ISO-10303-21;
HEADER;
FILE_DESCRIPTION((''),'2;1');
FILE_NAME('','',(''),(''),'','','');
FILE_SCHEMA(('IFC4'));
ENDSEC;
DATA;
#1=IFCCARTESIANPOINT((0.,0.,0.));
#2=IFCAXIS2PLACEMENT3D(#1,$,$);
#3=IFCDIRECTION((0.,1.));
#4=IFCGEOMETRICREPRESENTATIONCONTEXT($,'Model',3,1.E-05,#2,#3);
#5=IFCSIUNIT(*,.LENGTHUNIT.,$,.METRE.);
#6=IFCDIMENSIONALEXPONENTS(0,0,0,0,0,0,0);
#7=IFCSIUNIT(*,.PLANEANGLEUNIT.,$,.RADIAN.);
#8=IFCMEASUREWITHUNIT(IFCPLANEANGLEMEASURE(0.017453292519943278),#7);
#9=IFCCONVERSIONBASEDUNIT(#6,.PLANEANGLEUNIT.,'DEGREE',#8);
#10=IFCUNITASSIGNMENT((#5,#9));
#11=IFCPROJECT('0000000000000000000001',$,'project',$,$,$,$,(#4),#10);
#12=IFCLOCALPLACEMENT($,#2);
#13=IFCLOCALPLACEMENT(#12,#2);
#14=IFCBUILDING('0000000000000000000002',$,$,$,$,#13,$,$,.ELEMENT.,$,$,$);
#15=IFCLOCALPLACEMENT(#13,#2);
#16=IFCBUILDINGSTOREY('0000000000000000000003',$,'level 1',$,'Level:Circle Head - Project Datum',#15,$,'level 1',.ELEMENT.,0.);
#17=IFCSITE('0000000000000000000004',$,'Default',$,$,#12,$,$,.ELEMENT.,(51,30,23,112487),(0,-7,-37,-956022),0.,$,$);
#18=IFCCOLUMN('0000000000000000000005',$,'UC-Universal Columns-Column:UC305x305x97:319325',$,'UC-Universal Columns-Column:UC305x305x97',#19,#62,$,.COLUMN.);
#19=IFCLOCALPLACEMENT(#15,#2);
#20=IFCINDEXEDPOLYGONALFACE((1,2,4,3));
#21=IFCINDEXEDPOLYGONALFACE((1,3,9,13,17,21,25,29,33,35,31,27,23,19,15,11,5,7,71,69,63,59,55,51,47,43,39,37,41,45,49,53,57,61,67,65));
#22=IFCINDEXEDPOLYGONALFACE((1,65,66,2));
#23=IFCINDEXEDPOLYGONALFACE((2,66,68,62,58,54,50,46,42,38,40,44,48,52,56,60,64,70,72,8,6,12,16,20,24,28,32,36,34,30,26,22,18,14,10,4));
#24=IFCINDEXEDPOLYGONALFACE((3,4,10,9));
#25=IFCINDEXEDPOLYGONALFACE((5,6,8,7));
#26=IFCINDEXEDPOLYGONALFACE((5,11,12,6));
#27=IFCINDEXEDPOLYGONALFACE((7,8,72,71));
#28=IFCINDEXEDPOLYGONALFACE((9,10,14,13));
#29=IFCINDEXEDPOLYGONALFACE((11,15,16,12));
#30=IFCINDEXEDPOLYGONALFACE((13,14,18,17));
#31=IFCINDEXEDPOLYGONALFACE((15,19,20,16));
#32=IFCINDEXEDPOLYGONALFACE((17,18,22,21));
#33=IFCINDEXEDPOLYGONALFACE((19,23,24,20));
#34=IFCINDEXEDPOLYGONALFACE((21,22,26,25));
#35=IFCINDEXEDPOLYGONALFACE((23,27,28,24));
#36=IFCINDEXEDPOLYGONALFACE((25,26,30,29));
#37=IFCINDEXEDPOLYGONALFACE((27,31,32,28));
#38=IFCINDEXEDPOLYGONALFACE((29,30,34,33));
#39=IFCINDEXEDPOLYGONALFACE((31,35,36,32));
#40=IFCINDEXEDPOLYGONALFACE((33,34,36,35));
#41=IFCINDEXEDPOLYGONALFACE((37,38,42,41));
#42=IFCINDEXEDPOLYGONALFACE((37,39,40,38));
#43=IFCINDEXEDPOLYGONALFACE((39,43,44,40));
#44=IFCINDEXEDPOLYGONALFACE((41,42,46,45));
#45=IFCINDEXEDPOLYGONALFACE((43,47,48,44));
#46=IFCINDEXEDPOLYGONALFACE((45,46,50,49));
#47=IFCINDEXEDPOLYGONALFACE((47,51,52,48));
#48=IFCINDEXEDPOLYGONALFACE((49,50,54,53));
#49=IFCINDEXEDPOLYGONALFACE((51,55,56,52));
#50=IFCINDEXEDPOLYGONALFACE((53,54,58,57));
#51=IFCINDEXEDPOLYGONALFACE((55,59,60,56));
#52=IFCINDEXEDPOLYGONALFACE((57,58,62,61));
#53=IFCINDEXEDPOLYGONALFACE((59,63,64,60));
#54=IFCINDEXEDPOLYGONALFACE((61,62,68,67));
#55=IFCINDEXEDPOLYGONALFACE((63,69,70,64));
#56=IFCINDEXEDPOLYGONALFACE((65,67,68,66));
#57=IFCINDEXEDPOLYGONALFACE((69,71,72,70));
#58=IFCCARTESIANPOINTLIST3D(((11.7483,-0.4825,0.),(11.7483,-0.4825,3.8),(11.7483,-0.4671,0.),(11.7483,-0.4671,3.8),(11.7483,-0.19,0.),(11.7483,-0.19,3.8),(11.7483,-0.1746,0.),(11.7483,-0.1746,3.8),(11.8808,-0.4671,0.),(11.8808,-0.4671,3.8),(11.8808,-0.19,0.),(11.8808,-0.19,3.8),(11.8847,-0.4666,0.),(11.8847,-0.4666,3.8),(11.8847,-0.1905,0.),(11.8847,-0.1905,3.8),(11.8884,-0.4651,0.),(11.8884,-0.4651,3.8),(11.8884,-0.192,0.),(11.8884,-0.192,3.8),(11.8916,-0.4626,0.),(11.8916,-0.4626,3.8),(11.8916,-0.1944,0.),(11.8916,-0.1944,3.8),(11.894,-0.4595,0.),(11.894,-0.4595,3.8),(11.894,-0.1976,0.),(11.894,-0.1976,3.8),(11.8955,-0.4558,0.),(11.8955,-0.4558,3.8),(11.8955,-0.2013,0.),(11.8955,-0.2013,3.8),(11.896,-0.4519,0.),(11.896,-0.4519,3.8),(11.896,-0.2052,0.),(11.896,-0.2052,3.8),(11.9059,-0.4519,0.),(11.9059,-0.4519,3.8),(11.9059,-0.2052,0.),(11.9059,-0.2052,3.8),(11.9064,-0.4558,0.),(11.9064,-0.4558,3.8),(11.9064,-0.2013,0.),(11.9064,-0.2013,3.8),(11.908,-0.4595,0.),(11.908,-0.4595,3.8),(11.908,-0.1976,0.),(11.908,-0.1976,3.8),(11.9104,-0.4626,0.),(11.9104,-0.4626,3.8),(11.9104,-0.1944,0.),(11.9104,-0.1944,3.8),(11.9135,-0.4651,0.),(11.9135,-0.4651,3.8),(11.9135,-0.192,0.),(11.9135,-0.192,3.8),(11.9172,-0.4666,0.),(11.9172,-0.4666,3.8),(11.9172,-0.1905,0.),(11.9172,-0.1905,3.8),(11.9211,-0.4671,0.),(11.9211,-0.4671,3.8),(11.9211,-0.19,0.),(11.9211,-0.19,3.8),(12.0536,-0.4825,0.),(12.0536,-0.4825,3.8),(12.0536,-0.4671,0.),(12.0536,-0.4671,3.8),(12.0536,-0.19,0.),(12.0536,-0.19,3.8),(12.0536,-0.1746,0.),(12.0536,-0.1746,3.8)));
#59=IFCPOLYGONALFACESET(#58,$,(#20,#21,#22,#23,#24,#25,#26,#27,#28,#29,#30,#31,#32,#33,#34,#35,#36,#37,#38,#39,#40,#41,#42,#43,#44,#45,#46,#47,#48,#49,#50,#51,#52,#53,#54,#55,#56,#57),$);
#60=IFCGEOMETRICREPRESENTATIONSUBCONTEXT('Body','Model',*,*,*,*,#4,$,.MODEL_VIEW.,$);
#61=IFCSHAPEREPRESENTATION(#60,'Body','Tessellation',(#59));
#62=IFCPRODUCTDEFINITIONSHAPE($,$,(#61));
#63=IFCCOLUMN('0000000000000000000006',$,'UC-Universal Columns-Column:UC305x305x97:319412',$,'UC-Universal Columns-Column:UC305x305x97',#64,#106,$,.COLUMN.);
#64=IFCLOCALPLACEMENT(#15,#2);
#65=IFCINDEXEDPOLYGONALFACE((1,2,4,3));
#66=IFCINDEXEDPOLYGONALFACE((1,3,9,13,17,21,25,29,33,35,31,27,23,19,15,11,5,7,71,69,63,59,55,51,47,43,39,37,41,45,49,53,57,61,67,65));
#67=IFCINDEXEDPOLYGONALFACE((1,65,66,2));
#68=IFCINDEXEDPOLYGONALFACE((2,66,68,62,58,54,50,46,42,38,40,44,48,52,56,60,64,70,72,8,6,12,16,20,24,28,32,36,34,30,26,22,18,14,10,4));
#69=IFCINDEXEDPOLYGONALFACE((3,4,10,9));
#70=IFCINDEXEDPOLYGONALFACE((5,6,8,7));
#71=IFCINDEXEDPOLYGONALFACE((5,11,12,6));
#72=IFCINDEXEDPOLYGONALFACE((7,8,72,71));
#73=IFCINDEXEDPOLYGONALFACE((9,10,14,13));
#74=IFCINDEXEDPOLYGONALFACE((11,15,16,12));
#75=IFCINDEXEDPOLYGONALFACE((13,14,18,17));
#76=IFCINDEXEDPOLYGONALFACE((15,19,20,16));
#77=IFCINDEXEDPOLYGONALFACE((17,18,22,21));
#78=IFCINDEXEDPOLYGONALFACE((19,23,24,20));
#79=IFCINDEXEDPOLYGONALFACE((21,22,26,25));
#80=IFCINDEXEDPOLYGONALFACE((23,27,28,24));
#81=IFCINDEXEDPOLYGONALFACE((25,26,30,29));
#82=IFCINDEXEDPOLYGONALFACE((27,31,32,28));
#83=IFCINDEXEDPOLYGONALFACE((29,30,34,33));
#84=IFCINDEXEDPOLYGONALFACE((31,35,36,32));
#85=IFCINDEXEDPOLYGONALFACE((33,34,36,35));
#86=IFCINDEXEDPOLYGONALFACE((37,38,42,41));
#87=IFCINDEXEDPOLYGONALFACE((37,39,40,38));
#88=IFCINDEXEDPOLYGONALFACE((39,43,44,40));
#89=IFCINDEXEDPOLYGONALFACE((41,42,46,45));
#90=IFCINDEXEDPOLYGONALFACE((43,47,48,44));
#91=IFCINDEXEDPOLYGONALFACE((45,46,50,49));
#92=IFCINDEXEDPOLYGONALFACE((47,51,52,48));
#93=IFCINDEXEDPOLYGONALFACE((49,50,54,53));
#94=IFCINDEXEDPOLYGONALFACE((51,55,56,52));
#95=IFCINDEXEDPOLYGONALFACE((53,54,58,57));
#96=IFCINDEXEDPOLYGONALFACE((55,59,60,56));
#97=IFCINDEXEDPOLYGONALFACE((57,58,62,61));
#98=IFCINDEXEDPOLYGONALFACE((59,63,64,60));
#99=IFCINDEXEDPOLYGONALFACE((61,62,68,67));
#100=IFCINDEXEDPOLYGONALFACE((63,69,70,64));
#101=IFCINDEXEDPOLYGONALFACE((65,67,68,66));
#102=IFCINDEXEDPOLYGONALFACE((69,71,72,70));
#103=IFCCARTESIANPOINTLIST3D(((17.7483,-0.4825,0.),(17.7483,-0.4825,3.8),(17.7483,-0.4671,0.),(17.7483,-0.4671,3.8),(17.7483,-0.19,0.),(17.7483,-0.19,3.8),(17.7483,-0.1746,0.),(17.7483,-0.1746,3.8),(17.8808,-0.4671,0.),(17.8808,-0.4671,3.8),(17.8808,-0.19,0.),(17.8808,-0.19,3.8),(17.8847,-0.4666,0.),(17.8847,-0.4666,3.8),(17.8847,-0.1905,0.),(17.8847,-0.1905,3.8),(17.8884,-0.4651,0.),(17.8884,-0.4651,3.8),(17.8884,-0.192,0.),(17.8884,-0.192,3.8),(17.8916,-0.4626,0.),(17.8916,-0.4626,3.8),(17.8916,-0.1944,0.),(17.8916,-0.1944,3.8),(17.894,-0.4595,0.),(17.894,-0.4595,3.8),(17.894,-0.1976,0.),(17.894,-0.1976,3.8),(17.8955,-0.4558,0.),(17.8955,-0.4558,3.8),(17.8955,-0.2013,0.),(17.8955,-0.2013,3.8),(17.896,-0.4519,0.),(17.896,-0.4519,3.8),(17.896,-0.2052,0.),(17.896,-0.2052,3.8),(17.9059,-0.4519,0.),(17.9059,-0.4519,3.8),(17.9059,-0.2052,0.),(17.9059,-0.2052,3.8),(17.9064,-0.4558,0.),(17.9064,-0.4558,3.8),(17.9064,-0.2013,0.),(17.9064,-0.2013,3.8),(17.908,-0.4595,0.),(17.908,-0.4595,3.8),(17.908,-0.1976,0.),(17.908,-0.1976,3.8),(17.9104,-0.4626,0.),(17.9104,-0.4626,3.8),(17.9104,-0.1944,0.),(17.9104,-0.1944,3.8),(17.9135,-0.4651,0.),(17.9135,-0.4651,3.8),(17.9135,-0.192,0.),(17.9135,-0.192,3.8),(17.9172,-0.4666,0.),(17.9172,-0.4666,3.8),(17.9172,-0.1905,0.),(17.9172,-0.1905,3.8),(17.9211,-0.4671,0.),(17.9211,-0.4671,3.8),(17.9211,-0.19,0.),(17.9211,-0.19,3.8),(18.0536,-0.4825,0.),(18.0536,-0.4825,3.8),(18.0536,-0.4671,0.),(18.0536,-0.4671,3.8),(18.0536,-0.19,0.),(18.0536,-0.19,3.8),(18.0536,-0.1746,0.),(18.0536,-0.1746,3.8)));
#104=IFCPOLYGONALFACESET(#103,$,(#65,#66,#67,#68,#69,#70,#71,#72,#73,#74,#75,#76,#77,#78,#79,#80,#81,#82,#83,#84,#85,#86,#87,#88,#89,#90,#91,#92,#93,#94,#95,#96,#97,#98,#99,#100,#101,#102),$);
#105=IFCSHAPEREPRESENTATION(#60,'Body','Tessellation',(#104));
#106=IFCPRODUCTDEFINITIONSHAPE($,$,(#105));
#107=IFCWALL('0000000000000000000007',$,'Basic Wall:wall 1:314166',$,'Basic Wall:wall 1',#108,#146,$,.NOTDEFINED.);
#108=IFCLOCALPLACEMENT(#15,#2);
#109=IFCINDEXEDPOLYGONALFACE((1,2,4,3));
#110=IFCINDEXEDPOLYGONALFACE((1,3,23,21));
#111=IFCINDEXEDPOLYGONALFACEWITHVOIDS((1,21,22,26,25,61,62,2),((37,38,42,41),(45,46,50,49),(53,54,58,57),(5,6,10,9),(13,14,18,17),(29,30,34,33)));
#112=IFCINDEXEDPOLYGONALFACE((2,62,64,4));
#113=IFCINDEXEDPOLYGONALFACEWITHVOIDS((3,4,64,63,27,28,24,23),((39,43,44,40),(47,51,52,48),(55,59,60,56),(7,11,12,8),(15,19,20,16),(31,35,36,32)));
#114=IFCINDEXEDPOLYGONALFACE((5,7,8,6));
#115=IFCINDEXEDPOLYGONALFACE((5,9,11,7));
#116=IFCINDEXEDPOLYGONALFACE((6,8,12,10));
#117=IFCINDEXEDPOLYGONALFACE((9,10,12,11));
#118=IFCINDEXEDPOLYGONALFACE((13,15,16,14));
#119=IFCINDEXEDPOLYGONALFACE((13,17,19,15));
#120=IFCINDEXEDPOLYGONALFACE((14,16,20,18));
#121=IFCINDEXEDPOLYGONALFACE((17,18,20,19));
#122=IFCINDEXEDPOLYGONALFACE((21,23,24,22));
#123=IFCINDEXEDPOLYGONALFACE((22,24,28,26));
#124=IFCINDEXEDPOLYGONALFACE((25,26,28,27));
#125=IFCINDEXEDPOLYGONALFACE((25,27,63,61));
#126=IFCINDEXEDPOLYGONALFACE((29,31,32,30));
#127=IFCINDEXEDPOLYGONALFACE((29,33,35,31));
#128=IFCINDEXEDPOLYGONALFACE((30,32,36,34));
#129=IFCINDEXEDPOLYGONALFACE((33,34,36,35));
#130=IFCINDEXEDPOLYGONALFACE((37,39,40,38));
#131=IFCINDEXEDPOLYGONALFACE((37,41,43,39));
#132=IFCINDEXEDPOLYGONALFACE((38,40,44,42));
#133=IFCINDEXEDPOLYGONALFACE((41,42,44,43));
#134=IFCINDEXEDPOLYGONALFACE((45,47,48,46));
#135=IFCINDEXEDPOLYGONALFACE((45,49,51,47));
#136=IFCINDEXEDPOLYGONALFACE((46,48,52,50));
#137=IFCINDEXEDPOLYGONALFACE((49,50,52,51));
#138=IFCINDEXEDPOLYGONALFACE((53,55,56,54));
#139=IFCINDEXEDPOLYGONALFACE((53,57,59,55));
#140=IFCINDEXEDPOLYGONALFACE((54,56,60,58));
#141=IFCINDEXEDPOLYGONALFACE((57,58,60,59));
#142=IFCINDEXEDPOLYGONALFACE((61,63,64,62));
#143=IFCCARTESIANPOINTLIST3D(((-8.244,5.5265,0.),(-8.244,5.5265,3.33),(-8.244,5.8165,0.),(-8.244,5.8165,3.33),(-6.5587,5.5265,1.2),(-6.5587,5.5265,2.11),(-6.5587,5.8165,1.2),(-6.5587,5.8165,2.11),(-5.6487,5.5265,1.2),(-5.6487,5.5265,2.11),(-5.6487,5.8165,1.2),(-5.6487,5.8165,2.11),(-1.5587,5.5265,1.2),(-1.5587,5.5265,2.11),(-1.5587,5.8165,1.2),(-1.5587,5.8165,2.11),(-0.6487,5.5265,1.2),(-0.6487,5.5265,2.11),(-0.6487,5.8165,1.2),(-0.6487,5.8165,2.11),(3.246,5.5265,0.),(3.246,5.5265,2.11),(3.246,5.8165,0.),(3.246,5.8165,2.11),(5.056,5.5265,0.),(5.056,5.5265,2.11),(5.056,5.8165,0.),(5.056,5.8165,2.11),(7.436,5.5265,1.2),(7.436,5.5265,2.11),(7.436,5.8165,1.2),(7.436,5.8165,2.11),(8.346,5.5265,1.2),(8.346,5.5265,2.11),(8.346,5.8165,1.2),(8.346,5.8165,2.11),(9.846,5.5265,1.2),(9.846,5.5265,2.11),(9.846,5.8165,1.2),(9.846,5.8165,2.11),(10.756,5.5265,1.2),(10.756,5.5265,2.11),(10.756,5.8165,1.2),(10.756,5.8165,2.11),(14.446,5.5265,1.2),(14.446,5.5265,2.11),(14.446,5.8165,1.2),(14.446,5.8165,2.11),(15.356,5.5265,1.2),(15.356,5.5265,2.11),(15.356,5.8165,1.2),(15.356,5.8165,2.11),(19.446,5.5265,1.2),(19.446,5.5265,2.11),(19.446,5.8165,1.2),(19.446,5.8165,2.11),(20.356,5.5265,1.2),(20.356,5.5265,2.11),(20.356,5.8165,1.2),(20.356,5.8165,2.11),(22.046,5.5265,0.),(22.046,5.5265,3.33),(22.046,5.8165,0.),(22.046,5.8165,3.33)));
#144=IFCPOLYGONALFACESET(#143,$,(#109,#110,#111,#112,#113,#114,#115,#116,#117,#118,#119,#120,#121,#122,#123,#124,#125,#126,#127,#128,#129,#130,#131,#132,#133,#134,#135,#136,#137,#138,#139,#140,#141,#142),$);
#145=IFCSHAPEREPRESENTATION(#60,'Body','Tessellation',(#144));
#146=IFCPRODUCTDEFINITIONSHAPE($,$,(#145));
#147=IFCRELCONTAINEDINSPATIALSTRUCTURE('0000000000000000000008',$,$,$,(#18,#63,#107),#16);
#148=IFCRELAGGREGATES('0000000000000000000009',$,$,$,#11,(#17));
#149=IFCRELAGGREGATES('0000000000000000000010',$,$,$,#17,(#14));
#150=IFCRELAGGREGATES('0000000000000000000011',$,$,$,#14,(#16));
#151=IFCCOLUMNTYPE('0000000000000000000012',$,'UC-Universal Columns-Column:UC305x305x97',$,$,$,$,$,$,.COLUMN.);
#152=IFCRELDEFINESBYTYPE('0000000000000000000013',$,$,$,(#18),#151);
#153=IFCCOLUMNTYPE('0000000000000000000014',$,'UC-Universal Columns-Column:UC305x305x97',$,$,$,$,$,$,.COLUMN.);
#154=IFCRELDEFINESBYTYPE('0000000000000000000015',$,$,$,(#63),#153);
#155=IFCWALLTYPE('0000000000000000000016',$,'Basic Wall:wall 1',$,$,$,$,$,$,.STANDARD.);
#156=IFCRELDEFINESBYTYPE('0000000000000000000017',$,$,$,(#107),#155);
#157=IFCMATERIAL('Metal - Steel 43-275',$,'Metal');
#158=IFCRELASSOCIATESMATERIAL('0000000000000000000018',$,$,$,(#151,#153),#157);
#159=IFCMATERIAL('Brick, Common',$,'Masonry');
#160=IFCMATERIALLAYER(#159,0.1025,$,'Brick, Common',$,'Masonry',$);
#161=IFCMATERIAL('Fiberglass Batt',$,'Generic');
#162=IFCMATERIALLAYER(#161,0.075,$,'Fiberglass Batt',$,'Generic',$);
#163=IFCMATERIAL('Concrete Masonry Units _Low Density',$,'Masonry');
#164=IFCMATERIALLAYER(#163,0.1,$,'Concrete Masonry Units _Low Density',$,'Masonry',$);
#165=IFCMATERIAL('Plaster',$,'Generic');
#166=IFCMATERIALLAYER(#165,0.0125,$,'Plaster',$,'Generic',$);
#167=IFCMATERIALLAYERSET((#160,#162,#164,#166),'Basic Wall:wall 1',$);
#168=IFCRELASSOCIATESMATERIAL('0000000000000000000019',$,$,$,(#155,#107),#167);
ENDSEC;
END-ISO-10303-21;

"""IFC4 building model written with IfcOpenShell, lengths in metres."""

from ifc_helpers import new_model, entity, si_unit, converted_unit, direction, frame, frame_2d, origin, place, context, subcontext, project, spatial, polyline, rectangle, i_section, extrude, clip, bounded_halfspace, source, transform, mapped, material, layer, layer_set, layer_usage, material_profile, profile_set, type_object, type_shapes, element, save


model = new_model("IFC4")

# Units and contexts
model_context = context("Model", 3, precision=1e-05, world=origin(), true_north=direction((0.0, 1.0)))
body_context = subcontext(model_context, "Body", "Model", "MODEL_VIEW")
ifc_project = project(units=[si_unit("LENGTHUNIT", "METRE"), converted_unit("PLANEANGLEUNIT", "DEGREE", entity("IfcPlaneAngleMeasure", 0.017453292519943278), si_unit("PLANEANGLEUNIT", "RADIAN"), dimensions=[0, 0, 0, 0, 0, 0, 0])], contexts=[model_context])

# Site, building, storey
site_placement = place(None, origin())
site = spatial("IfcSite", under=ifc_project, at=site_placement, Name="Default", CompositionType="ELEMENT", RefLatitude=(51, 30, 23, 112487), RefLongitude=(0, -7, -37, -956022), RefElevation=0.0)
building_placement = place(site_placement, origin())
building = spatial("IfcBuilding", under=site, at=building_placement, CompositionType="ELEMENT")
storey_placement = place(building_placement, origin())
storey = spatial("IfcBuildingStorey", under=building, at=storey_placement, Name="level 1", ObjectType="Level:Circle Head - Project Datum", LongName="level 1", CompositionType="ELEMENT", Elevation=0.0)

# Columns
ifc_material_1 = material(Name="Metal - Steel 43-275", Category="Metal")
ifc_material_profile = material_profile(ifc_material_1, i_section(OverallWidth=0.3053, OverallDepth=0.3079, WebThickness=0.0099, FlangeThickness=0.0154, FilletRadius=0.0152, at=frame_2d((0.0, 0.0), x_axis=(1.0, 0.0))), Name="UC305x305x97")
ifc_profile_set = profile_set([ifc_material_profile], Name="UC305x305x97")
column_type_1 = type_object("IfcColumnType", Name="UC-Universal Columns-Column:UC305x305x97", PredefinedType="COLUMN", material=ifc_profile_set)
shared_shape_1 = source(origin(), body_context, "Body", "SweptSolid", [
    extrude(i_section(OverallWidth=0.3053, OverallDepth=0.3079, WebThickness=0.0099, FlangeThickness=0.0154, FilletRadius=0.0152, at=frame_2d((0.0, 0.0), x_axis=(1.0, 0.0))), frame((11.901, -0.3285, 0.0), z_axis=(0.0, 0.0, 1.0), x_axis=(-1.0, 0.0, 0.0)), (0.0, 0.0, 1.0), 3.8),
])
type_shapes(column_type_1, [shared_shape_1])
column_1_placement = place(storey_placement, origin())
element("IfcColumn", 1, at=column_1_placement, inside=storey, type_object=column_type_1, Name="UC-Universal Columns-Column:UC305x305x97:319325", ObjectType="UC-Universal Columns-Column:UC305x305x97", PredefinedType="COLUMN", context=body_context, shape_type="MappedRepresentation", body=[
    mapped(shared_shape_1, transform((0.0, 0.0, 0.0), scale=1.0)),
])
column_type_2 = type_object("IfcColumnType", Name="UC-Universal Columns-Column:UC305x305x97", PredefinedType="COLUMN", material=ifc_profile_set)
shared_shape_2 = source(origin(), body_context, "Body", "SweptSolid", [
    extrude(i_section(OverallWidth=0.3053, OverallDepth=0.3079, WebThickness=0.0099, FlangeThickness=0.0154, FilletRadius=0.0152, at=frame_2d((0.0, 0.0), x_axis=(1.0, 0.0))), frame((17.901, -0.3285, 0.0), z_axis=(0.0, 0.0, 1.0), x_axis=(-1.0, 0.0, 0.0)), (0.0, 0.0, 1.0), 3.8),
])
type_shapes(column_type_2, [shared_shape_2])
column_2_placement = place(storey_placement, origin())
element("IfcColumn", 2, at=column_2_placement, inside=storey, type_object=column_type_2, Name="UC-Universal Columns-Column:UC305x305x97:319412", ObjectType="UC-Universal Columns-Column:UC305x305x97", PredefinedType="COLUMN", context=body_context, shape_type="MappedRepresentation", body=[
    mapped(shared_shape_2, transform((0.0, 0.0, 0.0), scale=1.0)),
])

# Wall, openings
ifc_material_2 = material(Name="Brick, Common", Category="Masonry")
ifc_layer_1 = layer(ifc_material_2, 0.1025, Name="Brick, Common", Category="Masonry")
ifc_material_3 = material(Name="Fiberglass Batt", Category="Generic")
ifc_layer_2 = layer(ifc_material_3, 0.075, Name="Fiberglass Batt", Category="Generic")
ifc_material_4 = material(Name="Concrete Masonry Units _Low Density", Category="Masonry")
ifc_layer_3 = layer(ifc_material_4, 0.1, Name="Concrete Masonry Units _Low Density", Category="Masonry")
ifc_material_5 = material(Name="Plaster", Category="Generic")
ifc_layer_4 = layer(ifc_material_5, 0.0125, Name="Plaster", Category="Generic")
ifc_layer_set_1 = layer_set([ifc_layer_1, ifc_layer_2, ifc_layer_3, ifc_layer_4], Name="Basic Wall:wall 1")
ifc_layer_usage_1 = layer_usage(ifc_layer_set_1, "AXIS2", "NEGATIVE", 0.145)
wall_type_1 = type_object("IfcWallType", Name="Basic Wall:wall 1", PredefinedType="STANDARD", material=ifc_layer_set_1)
wall_1_placement = place(storey_placement, frame((-8.244, 5.6715, 0.0)))
wall_1 = element("IfcWall", 3, at=wall_1_placement, inside=storey, type_object=wall_type_1, material=ifc_layer_usage_1, Name="Basic Wall:wall 1:314166", ObjectType="Basic Wall:wall 1", PredefinedType="NOTDEFINED", context=body_context, shape_type="Clipping", body=[
    clip(extrude(rectangle(XDim=30.29, YDim=0.29, at=frame_2d((15.145, 0.0), x_axis=(1.0, 0.0))), origin(), (0.0, 0.0, 1.0), 3.33), bounded_halfspace(frame((0.0, -0.145, 3.33), z_axis=(0.0, 0.0, -1.0), x_axis=(0.0, 1.0, 0.0)), True, frame((0.0, -0.145, 3.33)), polyline([(0.0, 0.0), (0.29, 0.0), (4.0731, 0.0), (4.1981, 0.0), (10.0825, 0.0), (10.2075, 0.0), (20.0825, 0.0), (20.2075, 0.0), (26.0825, 0.0), (26.2075, 0.0), (30.0, 0.0), (30.29, 0.0), (30.29, 0.29), (0.0, 0.29), (0.0, 0.0)]))),
])
opening_1_placement = place(wall_1_placement, frame((13.3, 0.145, 0.0)))
element("IfcOpeningElement", 4, at=opening_1_placement, cuts=wall_1, PredefinedType="OPENING", context=body_context, shape_type="SweptSolid", body=[
    extrude(rectangle(XDim=2.11, YDim=1.81, at=frame_2d((1.055, 0.905), x_axis=(-1.0, 0.0))), frame((0.0, 0.0, 0.0), z_axis=(0.0, -1.0, 0.0), x_axis=(0.0, 0.0, 1.0)), (0.0, 0.0, 1.0), 0.29),
])
opening_2_placement = place(wall_1_placement, frame((1.6853, -0.145, 1.2)))
element("IfcOpeningElement", 5, at=opening_2_placement, cuts=wall_1, PredefinedType="OPENING", context=body_context, shape_type="SweptSolid", body=[
    extrude(rectangle(XDim=0.91, YDim=0.91, at=frame_2d((0.455, 0.455), x_axis=(-1.0, 0.0))), frame((0.0, 0.0, 0.0), z_axis=(0.0, 1.0, 0.0), x_axis=(0.0, 0.0, 1.0)), (0.0, 0.0, 1.0), 0.29),
])
opening_3_placement = place(wall_1_placement, frame((6.6853, -0.145, 1.2)))
element("IfcOpeningElement", 6, at=opening_3_placement, cuts=wall_1, PredefinedType="OPENING", context=body_context, shape_type="SweptSolid", body=[
    extrude(rectangle(XDim=0.91, YDim=0.91, at=frame_2d((0.455, 0.455), x_axis=(-1.0, 0.0))), frame((0.0, 0.0, 0.0), z_axis=(0.0, 1.0, 0.0), x_axis=(0.0, 0.0, 1.0)), (0.0, 0.0, 1.0), 0.29),
])
opening_4_placement = place(wall_1_placement, frame((22.69, -0.145, 1.2)))
element("IfcOpeningElement", 7, at=opening_4_placement, cuts=wall_1, PredefinedType="OPENING", context=body_context, shape_type="SweptSolid", body=[
    extrude(rectangle(XDim=0.91, YDim=0.91, at=frame_2d((0.455, 0.455), x_axis=(-1.0, 0.0))), frame((0.0, 0.0, 0.0), z_axis=(0.0, 1.0, 0.0), x_axis=(0.0, 0.0, 1.0)), (0.0, 0.0, 1.0), 0.29),
])
opening_5_placement = place(wall_1_placement, frame((27.69, -0.145, 1.2)))
element("IfcOpeningElement", 8, at=opening_5_placement, cuts=wall_1, PredefinedType="OPENING", context=body_context, shape_type="SweptSolid", body=[
    extrude(rectangle(XDim=0.91, YDim=0.91, at=frame_2d((0.455, 0.455), x_axis=(-1.0, 0.0))), frame((0.0, 0.0, 0.0), z_axis=(0.0, 1.0, 0.0), x_axis=(0.0, 0.0, 1.0)), (0.0, 0.0, 1.0), 0.29),
])
opening_6_placement = place(wall_1_placement, frame((18.09, -0.145, 1.2)))
element("IfcOpeningElement", 9, at=opening_6_placement, cuts=wall_1, PredefinedType="OPENING", context=body_context, shape_type="SweptSolid", body=[
    extrude(rectangle(XDim=0.91, YDim=0.91, at=frame_2d((0.455, 0.455), x_axis=(-1.0, 0.0))), frame((0.0, 0.0, 0.0), z_axis=(0.0, 1.0, 0.0), x_axis=(0.0, 0.0, 1.0)), (0.0, 0.0, 1.0), 0.29),
])
opening_7_placement = place(wall_1_placement, frame((15.68, -0.145, 1.2)))
element("IfcOpeningElement", 10, at=opening_7_placement, cuts=wall_1, PredefinedType="OPENING", context=body_context, shape_type="SweptSolid", body=[
    extrude(rectangle(XDim=0.91, YDim=0.91, at=frame_2d((0.455, 0.455), x_axis=(-1.0, 0.0))), frame((0.0, 0.0, 0.0), z_axis=(0.0, 1.0, 0.0), x_axis=(0.0, 0.0, 1.0)), (0.0, 0.0, 1.0), 0.29),
])

save(model, "model.ifc")
